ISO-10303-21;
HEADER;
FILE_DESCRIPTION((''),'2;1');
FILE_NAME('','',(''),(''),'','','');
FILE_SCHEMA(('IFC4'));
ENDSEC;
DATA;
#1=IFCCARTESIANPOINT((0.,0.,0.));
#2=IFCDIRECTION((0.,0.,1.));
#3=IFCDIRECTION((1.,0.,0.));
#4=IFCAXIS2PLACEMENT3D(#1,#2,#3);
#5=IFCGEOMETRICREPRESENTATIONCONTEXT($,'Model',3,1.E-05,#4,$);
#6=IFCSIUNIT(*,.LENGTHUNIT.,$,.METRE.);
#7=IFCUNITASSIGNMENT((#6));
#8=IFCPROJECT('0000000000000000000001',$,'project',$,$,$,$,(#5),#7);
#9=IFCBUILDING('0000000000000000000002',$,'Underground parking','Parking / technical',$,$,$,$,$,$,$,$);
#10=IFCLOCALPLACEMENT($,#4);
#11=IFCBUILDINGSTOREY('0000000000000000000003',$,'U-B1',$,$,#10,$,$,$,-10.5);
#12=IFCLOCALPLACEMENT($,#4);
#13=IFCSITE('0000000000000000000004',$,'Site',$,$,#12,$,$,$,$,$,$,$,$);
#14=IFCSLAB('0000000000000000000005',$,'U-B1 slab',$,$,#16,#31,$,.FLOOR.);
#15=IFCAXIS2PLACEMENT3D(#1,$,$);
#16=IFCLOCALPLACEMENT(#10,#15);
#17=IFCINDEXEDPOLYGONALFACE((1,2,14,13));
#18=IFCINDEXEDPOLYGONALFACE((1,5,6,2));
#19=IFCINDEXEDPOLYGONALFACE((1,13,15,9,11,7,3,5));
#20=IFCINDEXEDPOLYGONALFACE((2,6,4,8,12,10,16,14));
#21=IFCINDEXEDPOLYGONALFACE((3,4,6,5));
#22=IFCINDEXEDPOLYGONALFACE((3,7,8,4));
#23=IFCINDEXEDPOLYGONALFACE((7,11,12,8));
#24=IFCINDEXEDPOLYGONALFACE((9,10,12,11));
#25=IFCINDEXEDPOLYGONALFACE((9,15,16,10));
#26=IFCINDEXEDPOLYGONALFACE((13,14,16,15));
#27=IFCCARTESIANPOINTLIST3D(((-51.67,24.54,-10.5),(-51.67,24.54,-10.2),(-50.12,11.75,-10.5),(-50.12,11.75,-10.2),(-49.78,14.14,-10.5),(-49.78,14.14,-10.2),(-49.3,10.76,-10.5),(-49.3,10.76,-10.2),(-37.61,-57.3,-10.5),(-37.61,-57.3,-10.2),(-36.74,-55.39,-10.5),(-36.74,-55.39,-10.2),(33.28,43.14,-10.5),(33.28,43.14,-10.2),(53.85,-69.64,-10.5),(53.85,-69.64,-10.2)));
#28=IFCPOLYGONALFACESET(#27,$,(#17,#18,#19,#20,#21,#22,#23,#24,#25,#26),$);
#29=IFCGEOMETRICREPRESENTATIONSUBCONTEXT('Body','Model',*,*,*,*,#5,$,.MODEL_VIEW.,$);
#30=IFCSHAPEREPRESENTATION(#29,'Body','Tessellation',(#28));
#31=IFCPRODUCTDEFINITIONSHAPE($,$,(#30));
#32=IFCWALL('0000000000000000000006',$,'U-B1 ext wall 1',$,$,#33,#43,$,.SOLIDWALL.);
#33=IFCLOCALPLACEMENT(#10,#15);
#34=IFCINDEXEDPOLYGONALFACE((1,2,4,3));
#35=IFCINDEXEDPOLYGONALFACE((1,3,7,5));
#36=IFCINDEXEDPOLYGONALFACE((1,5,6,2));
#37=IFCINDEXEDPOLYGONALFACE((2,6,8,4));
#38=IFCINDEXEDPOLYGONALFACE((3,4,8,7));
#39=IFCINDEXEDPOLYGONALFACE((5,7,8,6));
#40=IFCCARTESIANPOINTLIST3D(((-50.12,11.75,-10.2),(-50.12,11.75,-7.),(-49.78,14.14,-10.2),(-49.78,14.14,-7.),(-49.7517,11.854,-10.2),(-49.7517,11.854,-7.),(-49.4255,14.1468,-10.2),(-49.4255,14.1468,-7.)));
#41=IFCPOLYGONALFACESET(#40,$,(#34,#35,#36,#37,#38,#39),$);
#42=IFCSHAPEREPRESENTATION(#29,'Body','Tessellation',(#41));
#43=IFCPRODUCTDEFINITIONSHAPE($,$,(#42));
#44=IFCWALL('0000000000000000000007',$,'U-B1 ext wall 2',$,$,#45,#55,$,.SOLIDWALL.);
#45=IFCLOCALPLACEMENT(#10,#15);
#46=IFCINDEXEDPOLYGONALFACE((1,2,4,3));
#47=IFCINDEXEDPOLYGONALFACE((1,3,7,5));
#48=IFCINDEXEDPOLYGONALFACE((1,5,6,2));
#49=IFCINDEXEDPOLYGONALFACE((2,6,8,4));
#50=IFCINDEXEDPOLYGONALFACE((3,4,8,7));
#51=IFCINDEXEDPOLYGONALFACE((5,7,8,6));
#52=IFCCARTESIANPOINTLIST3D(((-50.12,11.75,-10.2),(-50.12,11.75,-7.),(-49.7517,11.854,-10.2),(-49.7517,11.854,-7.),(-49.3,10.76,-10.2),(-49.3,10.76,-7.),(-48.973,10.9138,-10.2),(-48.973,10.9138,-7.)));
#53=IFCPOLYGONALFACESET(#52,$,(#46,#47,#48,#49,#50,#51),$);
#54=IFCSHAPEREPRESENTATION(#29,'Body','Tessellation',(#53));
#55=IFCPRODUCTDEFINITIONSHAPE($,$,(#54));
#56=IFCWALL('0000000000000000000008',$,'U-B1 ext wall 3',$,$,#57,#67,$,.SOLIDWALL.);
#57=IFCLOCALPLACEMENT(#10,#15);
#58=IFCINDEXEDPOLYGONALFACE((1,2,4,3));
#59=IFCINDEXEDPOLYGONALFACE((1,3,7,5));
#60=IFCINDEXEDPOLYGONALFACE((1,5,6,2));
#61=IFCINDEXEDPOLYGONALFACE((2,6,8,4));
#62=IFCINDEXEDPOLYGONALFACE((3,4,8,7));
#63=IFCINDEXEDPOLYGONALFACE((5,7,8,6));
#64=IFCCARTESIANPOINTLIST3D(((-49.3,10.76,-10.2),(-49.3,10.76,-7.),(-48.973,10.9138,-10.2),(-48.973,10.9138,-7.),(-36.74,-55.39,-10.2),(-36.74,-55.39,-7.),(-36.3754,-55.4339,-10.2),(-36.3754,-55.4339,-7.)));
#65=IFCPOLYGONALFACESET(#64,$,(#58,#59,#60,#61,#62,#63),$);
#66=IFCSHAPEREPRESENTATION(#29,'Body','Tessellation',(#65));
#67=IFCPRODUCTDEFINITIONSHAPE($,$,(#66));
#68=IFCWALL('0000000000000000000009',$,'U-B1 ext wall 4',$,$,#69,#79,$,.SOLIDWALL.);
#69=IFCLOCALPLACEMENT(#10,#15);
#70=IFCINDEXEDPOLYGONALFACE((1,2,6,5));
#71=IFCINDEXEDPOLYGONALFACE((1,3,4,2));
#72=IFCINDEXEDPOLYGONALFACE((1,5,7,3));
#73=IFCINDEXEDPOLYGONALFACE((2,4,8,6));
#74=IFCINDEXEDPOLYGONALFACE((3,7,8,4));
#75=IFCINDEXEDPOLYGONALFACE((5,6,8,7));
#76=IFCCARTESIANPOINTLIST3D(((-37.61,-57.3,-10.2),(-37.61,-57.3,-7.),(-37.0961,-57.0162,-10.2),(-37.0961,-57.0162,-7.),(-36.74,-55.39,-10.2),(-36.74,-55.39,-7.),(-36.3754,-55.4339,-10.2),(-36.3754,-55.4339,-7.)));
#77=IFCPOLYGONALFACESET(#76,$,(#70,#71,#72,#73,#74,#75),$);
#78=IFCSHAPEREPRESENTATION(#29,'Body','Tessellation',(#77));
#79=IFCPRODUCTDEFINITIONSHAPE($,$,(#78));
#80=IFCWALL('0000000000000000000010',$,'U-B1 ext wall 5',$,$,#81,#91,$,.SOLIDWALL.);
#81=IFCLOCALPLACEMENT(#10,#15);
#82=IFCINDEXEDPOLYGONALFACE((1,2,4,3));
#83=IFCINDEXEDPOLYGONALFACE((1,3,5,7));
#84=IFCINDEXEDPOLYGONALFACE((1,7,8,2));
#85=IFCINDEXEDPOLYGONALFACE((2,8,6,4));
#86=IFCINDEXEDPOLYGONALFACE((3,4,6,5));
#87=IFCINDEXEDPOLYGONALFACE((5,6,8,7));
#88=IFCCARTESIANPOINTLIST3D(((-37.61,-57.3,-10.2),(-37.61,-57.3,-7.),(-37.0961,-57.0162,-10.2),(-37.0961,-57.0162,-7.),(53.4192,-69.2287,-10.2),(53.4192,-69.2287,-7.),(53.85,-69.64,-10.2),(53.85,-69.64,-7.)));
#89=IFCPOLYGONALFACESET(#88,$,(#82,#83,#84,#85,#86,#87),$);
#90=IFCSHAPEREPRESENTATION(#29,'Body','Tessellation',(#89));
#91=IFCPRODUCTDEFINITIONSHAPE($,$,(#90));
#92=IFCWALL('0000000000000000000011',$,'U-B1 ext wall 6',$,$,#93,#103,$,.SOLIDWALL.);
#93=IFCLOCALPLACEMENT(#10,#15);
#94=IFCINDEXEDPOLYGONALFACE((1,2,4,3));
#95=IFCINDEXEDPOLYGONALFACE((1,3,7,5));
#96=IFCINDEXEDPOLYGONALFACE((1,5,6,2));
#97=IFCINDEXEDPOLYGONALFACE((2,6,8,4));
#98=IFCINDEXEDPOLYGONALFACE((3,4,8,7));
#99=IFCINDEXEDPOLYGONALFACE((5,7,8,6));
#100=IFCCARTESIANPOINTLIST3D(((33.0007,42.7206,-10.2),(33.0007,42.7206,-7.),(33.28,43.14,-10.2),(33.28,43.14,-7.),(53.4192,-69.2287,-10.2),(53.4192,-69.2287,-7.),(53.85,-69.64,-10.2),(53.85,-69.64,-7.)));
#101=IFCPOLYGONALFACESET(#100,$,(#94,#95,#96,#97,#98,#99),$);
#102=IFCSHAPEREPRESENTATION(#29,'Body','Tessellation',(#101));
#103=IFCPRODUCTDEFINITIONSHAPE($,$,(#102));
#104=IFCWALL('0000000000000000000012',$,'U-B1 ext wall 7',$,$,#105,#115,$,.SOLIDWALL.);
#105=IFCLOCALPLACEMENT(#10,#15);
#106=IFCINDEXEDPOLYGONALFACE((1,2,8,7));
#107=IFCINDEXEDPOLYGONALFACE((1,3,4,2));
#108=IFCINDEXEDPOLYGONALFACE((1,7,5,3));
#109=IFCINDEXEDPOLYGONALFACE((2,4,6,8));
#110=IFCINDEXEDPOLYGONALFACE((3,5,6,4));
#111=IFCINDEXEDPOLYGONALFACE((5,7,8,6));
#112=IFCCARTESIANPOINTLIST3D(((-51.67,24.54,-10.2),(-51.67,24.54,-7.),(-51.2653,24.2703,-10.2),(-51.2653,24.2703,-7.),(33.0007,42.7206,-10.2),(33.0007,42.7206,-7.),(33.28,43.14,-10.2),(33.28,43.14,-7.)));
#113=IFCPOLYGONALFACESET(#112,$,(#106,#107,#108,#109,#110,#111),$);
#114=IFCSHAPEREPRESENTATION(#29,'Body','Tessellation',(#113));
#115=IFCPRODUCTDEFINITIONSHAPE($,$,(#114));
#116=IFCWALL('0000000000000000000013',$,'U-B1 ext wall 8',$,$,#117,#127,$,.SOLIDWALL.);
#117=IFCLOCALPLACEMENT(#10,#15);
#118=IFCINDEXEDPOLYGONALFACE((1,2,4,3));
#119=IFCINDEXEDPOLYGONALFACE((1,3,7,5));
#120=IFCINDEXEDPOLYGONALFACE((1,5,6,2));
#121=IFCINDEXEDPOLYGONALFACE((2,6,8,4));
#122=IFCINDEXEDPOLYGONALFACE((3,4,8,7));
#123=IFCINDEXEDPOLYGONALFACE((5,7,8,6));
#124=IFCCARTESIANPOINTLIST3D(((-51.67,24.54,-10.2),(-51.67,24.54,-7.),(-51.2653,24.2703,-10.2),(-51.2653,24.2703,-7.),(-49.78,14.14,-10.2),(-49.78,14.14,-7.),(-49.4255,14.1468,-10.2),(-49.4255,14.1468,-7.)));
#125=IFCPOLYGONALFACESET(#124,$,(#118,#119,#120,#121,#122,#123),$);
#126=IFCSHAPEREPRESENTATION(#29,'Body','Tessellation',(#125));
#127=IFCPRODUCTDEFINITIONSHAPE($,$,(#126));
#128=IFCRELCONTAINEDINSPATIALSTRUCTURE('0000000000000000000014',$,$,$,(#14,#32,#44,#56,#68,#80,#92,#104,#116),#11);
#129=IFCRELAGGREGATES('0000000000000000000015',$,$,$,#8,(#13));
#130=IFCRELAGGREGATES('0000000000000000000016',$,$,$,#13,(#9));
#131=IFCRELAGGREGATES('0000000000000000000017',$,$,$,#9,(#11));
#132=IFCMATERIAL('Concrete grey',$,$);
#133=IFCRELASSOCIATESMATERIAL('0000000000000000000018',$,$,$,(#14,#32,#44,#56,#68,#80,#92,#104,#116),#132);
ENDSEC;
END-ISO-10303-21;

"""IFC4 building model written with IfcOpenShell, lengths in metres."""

from ifc_helpers import new_model, si_unit, frame, origin_with_axes, place, context, subcontext, project, spatial, polyline, outline, extrude, material, element, save


model = new_model("IFC4")

# Units and contexts
model_context = context("Model", 3, precision=1e-05, world=origin_with_axes())
body_context = subcontext(model_context, "Body", "Model", "MODEL_VIEW")
ifc_project = project(units=[si_unit("LENGTHUNIT", "METRE")], contexts=[model_context])

# Site, building, storey
site_placement = place(None, origin_with_axes())
site = spatial("IfcSite", under=ifc_project, at=site_placement, Name="Site")
building = spatial("IfcBuilding", under=site, Name="Underground parking", Description="Parking / technical")
storey_placement = place(None, origin_with_axes())
storey = spatial("IfcBuildingStorey", under=building, at=storey_placement, Name="U-B1", Elevation=-10.5)

# Slab
ifc_material = material(Name="Concrete grey")
slab_placement = place(storey_placement, origin_with_axes())
element("IfcSlab", 1, at=slab_placement, inside=storey, material=ifc_material, Name="U-B1 slab", PredefinedType="FLOOR", context=body_context, shape_type="SweptSolid", body=[
    extrude(outline(polyline([(-49.78, 14.14), (-50.12, 11.75), (-49.3, 10.76), (-36.74, -55.39), (-37.61, -57.3), (53.85, -69.64), (33.28, 43.14), (-51.67, 24.54), (-49.78, 14.14)])), frame((0.0, 0.0, -10.5), z_axis=(0.0, 0.0, 1.0), x_axis=(1.0, 0.0, 0.0)), (0.0, 0.0, 1.0), 0.3),
])

# Walls
wall_1_placement = place(storey_placement, origin_with_axes())
element("IfcWall", 2, at=wall_1_placement, inside=storey, material=ifc_material, Name="U-B1 ext wall 1", PredefinedType="SOLIDWALL", context=body_context, shape_type="SweptSolid", body=[
    extrude(outline(polyline([(-49.78, 14.14), (-50.12, 11.75), (-49.7517, 11.854), (-49.4255, 14.1468), (-49.78, 14.14)])), frame((0.0, 0.0, -10.2), z_axis=(0.0, 0.0, 1.0), x_axis=(1.0, 0.0, 0.0)), (0.0, 0.0, 1.0), 3.2),
])
wall_2_placement = place(storey_placement, origin_with_axes())
element("IfcWall", 3, at=wall_2_placement, inside=storey, material=ifc_material, Name="U-B1 ext wall 2", PredefinedType="SOLIDWALL", context=body_context, shape_type="SweptSolid", body=[
    extrude(outline(polyline([(-50.12, 11.75), (-49.3, 10.76), (-48.973, 10.9138), (-49.7517, 11.854), (-50.12, 11.75)])), frame((0.0, 0.0, -10.2), z_axis=(0.0, 0.0, 1.0), x_axis=(1.0, 0.0, 0.0)), (0.0, 0.0, 1.0), 3.2),
])
wall_3_placement = place(storey_placement, origin_with_axes())
element("IfcWall", 4, at=wall_3_placement, inside=storey, material=ifc_material, Name="U-B1 ext wall 3", PredefinedType="SOLIDWALL", context=body_context, shape_type="SweptSolid", body=[
    extrude(outline(polyline([(-49.3, 10.76), (-36.74, -55.39), (-36.3754, -55.4339), (-48.973, 10.9138), (-49.3, 10.76)])), frame((0.0, 0.0, -10.2), z_axis=(0.0, 0.0, 1.0), x_axis=(1.0, 0.0, 0.0)), (0.0, 0.0, 1.0), 3.2),
])
wall_4_placement = place(storey_placement, origin_with_axes())
element("IfcWall", 5, at=wall_4_placement, inside=storey, material=ifc_material, Name="U-B1 ext wall 4", PredefinedType="SOLIDWALL", context=body_context, shape_type="SweptSolid", body=[
    extrude(outline(polyline([(-36.74, -55.39), (-37.61, -57.3), (-37.0961, -57.0162), (-36.3754, -55.4339), (-36.74, -55.39)])), frame((0.0, 0.0, -10.2), z_axis=(0.0, 0.0, 1.0), x_axis=(1.0, 0.0, 0.0)), (0.0, 0.0, 1.0), 3.2),
])
wall_5_placement = place(storey_placement, origin_with_axes())
element("IfcWall", 6, at=wall_5_placement, inside=storey, material=ifc_material, Name="U-B1 ext wall 5", PredefinedType="SOLIDWALL", context=body_context, shape_type="SweptSolid", body=[
    extrude(outline(polyline([(-37.61, -57.3), (53.85, -69.64), (53.4192, -69.2287), (-37.0961, -57.0162), (-37.61, -57.3)])), frame((0.0, 0.0, -10.2), z_axis=(0.0, 0.0, 1.0), x_axis=(1.0, 0.0, 0.0)), (0.0, 0.0, 1.0), 3.2),
])
wall_6_placement = place(storey_placement, origin_with_axes())
element("IfcWall", 7, at=wall_6_placement, inside=storey, material=ifc_material, Name="U-B1 ext wall 6", PredefinedType="SOLIDWALL", context=body_context, shape_type="SweptSolid", body=[
    extrude(outline(polyline([(53.85, -69.64), (33.28, 43.14), (33.0007, 42.7206), (53.4192, -69.2287), (53.85, -69.64)])), frame((0.0, 0.0, -10.2), z_axis=(0.0, 0.0, 1.0), x_axis=(1.0, 0.0, 0.0)), (0.0, 0.0, 1.0), 3.2),
])
wall_7_placement = place(storey_placement, origin_with_axes())
element("IfcWall", 8, at=wall_7_placement, inside=storey, material=ifc_material, Name="U-B1 ext wall 7", PredefinedType="SOLIDWALL", context=body_context, shape_type="SweptSolid", body=[
    extrude(outline(polyline([(33.28, 43.14), (-51.67, 24.54), (-51.2653, 24.2703), (33.0007, 42.7206), (33.28, 43.14)])), frame((0.0, 0.0, -10.2), z_axis=(0.0, 0.0, 1.0), x_axis=(1.0, 0.0, 0.0)), (0.0, 0.0, 1.0), 3.2),
])
wall_8_placement = place(storey_placement, origin_with_axes())
element("IfcWall", 9, at=wall_8_placement, inside=storey, material=ifc_material, Name="U-B1 ext wall 8", PredefinedType="SOLIDWALL", context=body_context, shape_type="SweptSolid", body=[
    extrude(outline(polyline([(-51.67, 24.54), (-49.78, 14.14), (-49.4255, 14.1468), (-51.2653, 24.2703), (-51.67, 24.54)])), frame((0.0, 0.0, -10.2), z_axis=(0.0, 0.0, 1.0), x_axis=(1.0, 0.0, 0.0)), (0.0, 0.0, 1.0), 3.2),
])

save(model, "model.ifc")
